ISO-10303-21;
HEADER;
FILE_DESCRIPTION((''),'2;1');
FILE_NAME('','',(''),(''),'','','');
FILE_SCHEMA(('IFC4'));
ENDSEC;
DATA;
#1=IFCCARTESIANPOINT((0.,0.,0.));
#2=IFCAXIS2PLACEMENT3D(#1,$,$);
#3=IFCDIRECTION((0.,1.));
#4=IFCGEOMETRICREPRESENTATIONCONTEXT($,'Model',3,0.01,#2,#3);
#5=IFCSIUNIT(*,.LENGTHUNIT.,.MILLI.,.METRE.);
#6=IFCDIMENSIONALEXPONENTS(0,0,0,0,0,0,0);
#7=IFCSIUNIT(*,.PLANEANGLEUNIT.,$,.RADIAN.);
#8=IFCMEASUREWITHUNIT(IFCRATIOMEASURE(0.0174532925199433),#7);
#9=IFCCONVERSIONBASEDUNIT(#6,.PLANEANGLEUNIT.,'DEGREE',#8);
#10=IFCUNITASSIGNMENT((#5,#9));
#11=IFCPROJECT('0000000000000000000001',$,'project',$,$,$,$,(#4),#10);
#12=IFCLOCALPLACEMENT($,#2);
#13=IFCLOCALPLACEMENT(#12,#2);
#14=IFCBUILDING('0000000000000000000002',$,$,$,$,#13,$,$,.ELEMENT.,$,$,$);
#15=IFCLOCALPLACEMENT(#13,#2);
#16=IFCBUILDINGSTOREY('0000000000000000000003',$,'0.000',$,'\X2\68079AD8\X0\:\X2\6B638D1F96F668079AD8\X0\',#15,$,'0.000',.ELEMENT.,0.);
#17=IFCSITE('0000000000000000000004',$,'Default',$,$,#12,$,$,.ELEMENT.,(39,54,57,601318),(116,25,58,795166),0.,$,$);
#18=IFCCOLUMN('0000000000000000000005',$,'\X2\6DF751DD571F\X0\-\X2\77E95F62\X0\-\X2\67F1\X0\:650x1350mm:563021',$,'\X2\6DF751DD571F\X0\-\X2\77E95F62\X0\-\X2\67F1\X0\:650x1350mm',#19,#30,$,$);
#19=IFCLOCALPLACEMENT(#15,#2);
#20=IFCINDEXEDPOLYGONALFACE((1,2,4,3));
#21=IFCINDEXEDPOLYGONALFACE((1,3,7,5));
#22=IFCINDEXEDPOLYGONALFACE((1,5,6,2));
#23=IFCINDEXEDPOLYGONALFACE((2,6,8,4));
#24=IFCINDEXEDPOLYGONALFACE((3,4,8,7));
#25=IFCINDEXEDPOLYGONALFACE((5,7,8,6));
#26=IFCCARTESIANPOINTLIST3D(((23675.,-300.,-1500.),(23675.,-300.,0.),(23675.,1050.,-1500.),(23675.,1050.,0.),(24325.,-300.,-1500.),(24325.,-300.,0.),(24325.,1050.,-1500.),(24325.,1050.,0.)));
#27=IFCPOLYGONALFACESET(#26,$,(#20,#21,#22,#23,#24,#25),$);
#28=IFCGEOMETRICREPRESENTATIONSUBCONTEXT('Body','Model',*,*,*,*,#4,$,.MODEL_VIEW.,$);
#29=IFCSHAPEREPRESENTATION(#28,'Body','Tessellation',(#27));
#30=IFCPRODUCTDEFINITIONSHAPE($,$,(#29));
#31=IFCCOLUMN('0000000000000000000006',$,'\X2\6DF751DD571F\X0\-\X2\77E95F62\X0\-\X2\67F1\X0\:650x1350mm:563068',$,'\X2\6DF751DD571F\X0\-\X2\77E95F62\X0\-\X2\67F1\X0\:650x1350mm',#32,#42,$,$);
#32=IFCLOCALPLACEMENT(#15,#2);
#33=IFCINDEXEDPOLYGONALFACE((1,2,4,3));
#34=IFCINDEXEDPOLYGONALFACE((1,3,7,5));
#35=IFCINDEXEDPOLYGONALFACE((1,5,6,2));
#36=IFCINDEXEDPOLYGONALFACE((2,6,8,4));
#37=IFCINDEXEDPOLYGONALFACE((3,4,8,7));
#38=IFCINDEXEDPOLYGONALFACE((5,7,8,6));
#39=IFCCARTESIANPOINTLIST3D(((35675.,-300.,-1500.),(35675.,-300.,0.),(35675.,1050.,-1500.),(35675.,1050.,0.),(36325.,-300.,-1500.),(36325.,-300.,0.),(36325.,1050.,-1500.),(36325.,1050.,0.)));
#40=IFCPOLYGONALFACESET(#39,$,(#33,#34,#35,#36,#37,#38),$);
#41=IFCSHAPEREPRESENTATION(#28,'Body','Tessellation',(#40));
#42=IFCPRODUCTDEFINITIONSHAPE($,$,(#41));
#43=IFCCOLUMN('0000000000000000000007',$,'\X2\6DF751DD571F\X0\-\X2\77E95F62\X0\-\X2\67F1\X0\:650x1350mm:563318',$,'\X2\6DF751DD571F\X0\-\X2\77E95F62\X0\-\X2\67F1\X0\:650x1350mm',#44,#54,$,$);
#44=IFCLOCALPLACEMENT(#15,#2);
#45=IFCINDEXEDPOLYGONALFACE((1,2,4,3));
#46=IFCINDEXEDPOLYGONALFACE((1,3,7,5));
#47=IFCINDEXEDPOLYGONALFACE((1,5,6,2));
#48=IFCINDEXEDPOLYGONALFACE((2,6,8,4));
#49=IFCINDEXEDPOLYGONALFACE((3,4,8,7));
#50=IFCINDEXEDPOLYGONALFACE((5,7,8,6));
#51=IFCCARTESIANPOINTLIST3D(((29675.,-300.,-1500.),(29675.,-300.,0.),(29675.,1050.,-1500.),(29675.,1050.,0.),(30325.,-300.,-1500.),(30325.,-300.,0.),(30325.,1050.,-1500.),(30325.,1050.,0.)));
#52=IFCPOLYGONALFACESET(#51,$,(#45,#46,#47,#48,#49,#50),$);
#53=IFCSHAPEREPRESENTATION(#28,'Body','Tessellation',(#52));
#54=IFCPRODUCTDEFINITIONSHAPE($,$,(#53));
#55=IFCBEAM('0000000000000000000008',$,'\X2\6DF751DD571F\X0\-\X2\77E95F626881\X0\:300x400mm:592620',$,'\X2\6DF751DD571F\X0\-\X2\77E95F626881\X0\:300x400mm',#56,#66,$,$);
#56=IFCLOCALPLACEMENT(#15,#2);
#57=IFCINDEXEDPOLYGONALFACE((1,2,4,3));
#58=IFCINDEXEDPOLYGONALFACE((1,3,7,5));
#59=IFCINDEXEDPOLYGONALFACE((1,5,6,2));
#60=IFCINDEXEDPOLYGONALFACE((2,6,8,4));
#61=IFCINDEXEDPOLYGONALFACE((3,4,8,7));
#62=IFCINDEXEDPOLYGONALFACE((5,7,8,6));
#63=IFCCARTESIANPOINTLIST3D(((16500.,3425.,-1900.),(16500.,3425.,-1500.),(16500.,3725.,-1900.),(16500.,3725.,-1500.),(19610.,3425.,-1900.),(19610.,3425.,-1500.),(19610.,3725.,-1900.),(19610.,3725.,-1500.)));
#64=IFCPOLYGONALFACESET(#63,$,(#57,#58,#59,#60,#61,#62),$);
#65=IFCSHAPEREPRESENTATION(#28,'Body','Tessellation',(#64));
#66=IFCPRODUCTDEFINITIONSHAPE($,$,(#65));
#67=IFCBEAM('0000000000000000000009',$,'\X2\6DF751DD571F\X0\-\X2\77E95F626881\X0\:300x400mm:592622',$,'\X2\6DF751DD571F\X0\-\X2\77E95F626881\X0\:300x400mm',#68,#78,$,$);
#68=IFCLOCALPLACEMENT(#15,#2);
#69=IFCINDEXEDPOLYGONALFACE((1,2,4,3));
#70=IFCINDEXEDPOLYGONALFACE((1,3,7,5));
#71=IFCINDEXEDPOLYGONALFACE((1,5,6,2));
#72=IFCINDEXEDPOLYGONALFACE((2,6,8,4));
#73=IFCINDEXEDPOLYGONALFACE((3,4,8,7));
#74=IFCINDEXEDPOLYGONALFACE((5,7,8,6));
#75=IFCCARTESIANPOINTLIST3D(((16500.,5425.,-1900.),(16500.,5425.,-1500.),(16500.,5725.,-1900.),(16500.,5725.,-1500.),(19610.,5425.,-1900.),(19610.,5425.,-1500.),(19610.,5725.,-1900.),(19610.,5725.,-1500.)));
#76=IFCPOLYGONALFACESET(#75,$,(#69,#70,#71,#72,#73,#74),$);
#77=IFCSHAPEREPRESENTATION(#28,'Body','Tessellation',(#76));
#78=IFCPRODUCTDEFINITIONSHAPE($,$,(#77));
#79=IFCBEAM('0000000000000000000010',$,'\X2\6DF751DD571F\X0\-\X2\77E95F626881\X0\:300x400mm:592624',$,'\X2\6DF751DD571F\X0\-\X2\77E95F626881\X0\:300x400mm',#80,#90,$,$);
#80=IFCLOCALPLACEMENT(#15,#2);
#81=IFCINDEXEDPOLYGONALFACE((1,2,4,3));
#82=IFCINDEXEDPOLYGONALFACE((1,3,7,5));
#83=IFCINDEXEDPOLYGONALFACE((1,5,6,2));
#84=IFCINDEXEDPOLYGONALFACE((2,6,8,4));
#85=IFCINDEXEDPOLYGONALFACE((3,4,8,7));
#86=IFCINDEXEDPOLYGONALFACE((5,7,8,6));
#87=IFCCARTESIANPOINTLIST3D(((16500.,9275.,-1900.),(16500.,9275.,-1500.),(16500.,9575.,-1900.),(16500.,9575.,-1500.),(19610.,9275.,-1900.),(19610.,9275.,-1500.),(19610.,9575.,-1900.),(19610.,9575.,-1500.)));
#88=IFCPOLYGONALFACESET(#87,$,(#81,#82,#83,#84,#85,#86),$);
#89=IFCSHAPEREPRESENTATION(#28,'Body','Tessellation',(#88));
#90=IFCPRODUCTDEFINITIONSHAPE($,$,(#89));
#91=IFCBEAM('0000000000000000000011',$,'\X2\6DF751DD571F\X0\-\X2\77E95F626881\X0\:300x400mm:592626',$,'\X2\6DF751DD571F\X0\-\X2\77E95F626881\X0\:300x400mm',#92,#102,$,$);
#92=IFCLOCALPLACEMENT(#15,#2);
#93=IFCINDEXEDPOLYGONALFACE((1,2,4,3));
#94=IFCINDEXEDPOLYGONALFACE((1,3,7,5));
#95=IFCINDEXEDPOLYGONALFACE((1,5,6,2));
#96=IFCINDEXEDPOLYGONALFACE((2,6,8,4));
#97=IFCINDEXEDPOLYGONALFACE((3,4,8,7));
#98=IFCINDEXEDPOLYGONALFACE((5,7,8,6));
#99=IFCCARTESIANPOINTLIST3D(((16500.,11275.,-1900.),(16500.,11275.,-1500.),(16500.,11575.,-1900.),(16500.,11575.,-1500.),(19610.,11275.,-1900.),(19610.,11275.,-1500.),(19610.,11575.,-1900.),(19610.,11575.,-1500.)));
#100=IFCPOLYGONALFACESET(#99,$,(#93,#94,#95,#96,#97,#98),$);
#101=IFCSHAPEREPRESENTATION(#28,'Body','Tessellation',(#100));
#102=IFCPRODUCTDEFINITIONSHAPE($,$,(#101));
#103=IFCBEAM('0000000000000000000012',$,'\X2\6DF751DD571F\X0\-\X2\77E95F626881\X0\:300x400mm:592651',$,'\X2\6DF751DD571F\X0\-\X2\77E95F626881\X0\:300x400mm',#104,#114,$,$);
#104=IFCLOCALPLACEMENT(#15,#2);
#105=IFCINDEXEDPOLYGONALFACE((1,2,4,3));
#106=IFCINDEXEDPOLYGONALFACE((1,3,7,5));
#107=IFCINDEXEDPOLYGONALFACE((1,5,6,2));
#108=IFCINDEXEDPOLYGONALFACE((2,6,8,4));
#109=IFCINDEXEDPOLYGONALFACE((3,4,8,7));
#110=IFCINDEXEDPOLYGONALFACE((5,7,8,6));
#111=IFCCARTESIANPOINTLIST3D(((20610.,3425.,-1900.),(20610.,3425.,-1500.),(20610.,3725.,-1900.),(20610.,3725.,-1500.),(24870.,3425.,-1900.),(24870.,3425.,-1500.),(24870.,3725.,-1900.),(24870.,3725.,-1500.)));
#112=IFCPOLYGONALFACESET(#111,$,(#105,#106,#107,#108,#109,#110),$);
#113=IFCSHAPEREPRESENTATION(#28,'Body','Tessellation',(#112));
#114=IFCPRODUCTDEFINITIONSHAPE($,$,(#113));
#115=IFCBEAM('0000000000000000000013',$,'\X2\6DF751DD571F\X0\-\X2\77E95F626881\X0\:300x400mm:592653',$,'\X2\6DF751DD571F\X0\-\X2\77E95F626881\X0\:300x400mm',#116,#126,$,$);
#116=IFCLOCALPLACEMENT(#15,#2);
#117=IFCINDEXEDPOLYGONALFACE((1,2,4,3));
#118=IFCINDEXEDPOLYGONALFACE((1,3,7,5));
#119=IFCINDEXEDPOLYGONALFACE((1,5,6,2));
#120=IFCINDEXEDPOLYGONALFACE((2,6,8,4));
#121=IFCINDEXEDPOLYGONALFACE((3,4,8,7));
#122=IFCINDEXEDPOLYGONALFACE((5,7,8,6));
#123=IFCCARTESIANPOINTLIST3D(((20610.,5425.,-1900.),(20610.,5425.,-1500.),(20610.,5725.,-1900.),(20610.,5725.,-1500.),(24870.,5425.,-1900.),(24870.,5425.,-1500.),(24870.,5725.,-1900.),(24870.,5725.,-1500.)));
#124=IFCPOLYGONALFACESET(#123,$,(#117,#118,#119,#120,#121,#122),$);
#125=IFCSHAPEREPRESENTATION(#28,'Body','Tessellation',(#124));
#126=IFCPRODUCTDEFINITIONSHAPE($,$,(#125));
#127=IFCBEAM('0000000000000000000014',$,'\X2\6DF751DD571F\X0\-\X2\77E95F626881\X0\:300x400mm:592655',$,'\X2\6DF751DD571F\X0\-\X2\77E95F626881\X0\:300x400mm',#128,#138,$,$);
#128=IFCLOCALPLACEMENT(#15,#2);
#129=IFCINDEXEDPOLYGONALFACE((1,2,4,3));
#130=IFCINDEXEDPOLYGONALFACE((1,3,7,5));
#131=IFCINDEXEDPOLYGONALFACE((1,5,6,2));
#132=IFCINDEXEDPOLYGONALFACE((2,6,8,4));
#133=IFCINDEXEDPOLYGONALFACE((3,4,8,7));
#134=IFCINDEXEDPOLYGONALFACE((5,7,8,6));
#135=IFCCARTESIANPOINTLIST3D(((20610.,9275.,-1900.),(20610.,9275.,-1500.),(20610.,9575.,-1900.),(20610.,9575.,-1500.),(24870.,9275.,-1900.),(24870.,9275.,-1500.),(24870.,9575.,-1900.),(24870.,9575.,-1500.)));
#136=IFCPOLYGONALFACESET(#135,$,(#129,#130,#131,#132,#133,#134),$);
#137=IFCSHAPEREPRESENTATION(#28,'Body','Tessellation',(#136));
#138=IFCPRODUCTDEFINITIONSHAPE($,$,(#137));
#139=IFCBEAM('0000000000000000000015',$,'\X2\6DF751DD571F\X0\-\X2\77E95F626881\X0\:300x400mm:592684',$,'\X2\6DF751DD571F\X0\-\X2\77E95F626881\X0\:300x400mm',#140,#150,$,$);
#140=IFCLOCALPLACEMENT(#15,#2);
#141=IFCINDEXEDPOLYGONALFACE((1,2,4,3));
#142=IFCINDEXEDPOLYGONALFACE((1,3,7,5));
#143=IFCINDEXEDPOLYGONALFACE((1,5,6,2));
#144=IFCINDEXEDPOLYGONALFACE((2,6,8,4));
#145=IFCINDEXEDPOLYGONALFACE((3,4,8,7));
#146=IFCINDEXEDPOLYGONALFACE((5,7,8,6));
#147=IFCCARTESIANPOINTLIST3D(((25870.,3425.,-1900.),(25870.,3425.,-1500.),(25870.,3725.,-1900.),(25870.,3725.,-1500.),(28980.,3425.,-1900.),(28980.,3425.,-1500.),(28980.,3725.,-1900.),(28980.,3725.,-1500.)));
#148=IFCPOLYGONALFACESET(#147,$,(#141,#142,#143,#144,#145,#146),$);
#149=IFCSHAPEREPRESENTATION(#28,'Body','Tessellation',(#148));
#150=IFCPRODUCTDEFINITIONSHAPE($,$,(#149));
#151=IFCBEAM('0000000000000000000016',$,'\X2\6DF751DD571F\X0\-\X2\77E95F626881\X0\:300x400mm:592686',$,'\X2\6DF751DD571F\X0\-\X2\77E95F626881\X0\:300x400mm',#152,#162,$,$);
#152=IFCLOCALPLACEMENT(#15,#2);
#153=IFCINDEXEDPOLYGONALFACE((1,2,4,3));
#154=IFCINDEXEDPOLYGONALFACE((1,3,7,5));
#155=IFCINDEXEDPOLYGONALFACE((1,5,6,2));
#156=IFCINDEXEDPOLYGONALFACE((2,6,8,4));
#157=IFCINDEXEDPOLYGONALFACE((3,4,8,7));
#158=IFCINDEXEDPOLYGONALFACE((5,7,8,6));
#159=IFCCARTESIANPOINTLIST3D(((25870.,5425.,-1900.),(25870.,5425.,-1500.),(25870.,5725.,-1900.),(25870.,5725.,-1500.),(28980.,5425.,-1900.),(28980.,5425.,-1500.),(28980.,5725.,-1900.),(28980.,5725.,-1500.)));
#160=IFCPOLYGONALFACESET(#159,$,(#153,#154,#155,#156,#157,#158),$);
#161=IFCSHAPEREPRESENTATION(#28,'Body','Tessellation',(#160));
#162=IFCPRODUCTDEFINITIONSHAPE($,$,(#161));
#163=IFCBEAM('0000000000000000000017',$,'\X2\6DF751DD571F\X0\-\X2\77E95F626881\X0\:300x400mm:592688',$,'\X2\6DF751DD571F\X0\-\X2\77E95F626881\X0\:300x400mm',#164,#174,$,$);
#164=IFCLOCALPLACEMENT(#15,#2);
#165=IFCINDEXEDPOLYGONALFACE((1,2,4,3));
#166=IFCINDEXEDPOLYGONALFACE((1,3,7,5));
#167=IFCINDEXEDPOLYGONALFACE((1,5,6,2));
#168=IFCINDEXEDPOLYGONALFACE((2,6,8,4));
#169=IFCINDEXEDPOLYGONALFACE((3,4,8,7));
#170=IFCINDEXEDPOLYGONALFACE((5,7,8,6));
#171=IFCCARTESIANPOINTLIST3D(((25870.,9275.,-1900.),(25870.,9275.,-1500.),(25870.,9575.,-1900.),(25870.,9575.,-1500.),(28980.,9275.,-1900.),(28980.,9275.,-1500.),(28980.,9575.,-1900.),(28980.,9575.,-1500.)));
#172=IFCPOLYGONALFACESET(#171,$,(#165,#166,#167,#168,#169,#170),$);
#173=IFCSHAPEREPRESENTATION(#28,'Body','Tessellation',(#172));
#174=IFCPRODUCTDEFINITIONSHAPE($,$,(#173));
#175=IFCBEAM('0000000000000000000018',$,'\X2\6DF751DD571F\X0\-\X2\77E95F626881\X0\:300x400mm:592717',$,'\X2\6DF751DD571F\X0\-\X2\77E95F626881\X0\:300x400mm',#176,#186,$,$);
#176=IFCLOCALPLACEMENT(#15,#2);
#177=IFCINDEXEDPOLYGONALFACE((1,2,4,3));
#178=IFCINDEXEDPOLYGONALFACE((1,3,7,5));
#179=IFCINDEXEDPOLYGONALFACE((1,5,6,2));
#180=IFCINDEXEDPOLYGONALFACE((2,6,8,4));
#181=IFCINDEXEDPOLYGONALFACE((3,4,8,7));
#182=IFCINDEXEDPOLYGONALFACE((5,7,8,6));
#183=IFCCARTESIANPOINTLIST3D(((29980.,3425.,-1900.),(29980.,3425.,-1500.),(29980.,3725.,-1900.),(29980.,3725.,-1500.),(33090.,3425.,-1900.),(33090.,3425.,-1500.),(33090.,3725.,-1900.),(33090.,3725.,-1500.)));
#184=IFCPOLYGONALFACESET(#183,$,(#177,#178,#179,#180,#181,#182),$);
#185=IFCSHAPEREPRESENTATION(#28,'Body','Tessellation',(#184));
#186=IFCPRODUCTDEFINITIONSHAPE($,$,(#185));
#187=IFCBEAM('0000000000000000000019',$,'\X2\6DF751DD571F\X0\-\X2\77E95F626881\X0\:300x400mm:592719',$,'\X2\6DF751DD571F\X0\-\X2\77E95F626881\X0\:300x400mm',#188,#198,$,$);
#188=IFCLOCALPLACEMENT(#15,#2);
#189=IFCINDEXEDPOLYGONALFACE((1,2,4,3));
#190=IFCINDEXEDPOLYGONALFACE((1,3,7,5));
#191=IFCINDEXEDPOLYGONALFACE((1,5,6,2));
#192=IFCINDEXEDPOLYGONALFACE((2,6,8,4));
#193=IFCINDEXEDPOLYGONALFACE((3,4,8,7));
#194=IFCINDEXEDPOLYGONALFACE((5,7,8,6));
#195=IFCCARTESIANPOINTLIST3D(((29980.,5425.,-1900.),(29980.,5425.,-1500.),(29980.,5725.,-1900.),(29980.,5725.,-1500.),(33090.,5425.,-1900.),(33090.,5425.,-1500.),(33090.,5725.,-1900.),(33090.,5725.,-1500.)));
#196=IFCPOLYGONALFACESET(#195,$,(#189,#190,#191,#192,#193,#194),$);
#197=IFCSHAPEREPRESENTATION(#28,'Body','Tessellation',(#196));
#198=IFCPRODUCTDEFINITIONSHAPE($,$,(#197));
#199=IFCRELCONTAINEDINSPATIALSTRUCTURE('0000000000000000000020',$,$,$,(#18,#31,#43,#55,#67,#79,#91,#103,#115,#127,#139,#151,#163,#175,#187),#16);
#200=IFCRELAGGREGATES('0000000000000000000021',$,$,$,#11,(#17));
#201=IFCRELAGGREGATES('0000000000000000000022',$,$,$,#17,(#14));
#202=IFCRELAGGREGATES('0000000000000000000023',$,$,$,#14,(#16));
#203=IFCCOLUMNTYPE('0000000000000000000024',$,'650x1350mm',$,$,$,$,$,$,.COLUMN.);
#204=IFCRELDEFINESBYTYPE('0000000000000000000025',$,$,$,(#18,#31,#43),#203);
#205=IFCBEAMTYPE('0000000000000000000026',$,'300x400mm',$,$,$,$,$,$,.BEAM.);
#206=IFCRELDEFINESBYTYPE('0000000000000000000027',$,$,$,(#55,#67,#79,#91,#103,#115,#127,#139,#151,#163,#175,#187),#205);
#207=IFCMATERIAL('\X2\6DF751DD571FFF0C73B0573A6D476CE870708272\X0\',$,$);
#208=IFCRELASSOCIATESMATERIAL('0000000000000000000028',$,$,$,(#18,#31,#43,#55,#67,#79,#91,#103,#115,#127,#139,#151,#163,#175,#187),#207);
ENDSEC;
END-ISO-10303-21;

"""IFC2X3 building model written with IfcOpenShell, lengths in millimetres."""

from ifc_helpers import new_model, entity, si_unit, converted_unit, direction, frame, frame_2d, origin, origin_2d_with_axis, place, context, subcontext, project, spatial, rectangle, extrude, source, transform, mapped, material, type_object, type_shapes, element, save


model = new_model("IFC2X3")

# Units and contexts
model_context = context("Model", 3, precision=0.01, world=origin(), true_north=direction((0.0, 1.0)))
body_context = subcontext(model_context, "Body", "Model", "MODEL_VIEW")
ifc_project = project(units=[si_unit("LENGTHUNIT", "METRE", prefix="MILLI"), converted_unit("PLANEANGLEUNIT", "DEGREE", entity("IfcRatioMeasure", 0.0174532925199433), si_unit("PLANEANGLEUNIT", "RADIAN"), dimensions=[0, 0, 0, 0, 0, 0, 0])], contexts=[model_context])

# Site, building, storey
site_placement = place(None, origin())
site = spatial("IfcSite", under=ifc_project, at=site_placement, Name="Default", CompositionType="ELEMENT", RefLatitude=(39, 54, 57, 601318), RefLongitude=(116, 25, 58, 795166), RefElevation=0.0)
building_placement = place(site_placement, origin())
building = spatial("IfcBuilding", under=site, at=building_placement, CompositionType="ELEMENT")
storey_placement = place(building_placement, origin())
storey = spatial("IfcBuildingStorey", under=building, at=storey_placement, Name="0.000", ObjectType="标高:正负零标高", LongName="0.000", CompositionType="ELEMENT", Elevation=0.0)

# Columns
ifc_material = material(Name="混凝土，现场浇注灰色")
column_type = type_object("IfcColumnType", Name="650x1350mm", PredefinedType="COLUMN")
shared_shape = source(origin(), body_context, "Body", "SweptSolid", [
    extrude(rectangle(XDim=1350.0, YDim=650.0, at=origin_2d_with_axis()), frame((0.0, 0.0, -1500.0), z_axis=(0.0, 0.0, 1.0), x_axis=(0.0, -1.0, 0.0)), (0.0, 0.0, 1.0), 1500.0),
])
type_shapes(column_type, [shared_shape])
for number, where, name in (
    (1, (24000.0, 375.0, 0.0), "混凝土-矩形-柱:650x1350mm:563021"),
    (2, (36000.0, 375.0, 0.0), "混凝土-矩形-柱:650x1350mm:563068"),
    (3, (30000.0, 375.0, 0.0), "混凝土-矩形-柱:650x1350mm:563318"),
):
    element("IfcColumn", number, at=place(storey_placement, frame(where)), inside=storey, type_object=column_type, material=ifc_material, Name=name, ObjectType="混凝土-矩形-柱:650x1350mm", context=body_context, shape_type="MappedRepresentation", body=[
        mapped(shared_shape, transform((0.0, 0.0, 0.0), scale=1.0)),
    ])

# Beams
beam_type_1 = type_object("IfcBeamType", Name="300x400mm", PredefinedType="BEAM")
beam_1_placement = place(storey_placement, frame((19610.0, 3575.0, -1500.0), z_axis=(0.0, 0.0, 1.0), x_axis=(-1.0, 0.0, 0.0)))
element("IfcBeam", 4, at=beam_1_placement, inside=storey, type_object=beam_type_1, material=ifc_material, Name="混凝土-矩形梁:300x400mm:592620", ObjectType="混凝土-矩形梁:300x400mm", context=body_context, shape_type="SweptSolid", body=[
    extrude(rectangle(XDim=400.0, YDim=300.0, at=frame_2d((0.0, 0.0), x_axis=(1.0, 0.0))), frame((0.0, 0.0, -200.0), z_axis=(1.0, 0.0, 0.0), x_axis=(0.0, 0.0, -1.0)), (0.0, 0.0, 1.0), 3110.0),
])
beam_2_placement = place(storey_placement, frame((19610.0, 5575.0, -1500.0), z_axis=(0.0, 0.0, 1.0), x_axis=(-1.0, 0.0, 0.0)))
element("IfcBeam", 5, at=beam_2_placement, inside=storey, type_object=beam_type_1, material=ifc_material, Name="混凝土-矩形梁:300x400mm:592622", ObjectType="混凝土-矩形梁:300x400mm", context=body_context, shape_type="SweptSolid", body=[
    extrude(rectangle(XDim=400.0, YDim=300.0, at=frame_2d((0.0, 0.0), x_axis=(1.0, 0.0))), frame((0.0, 0.0, -200.0), z_axis=(1.0, 0.0, 0.0), x_axis=(0.0, 0.0, -1.0)), (0.0, 0.0, 1.0), 3110.0),
])
beam_3_placement = place(storey_placement, frame((19610.0, 9425.0, -1500.0), z_axis=(0.0, 0.0, 1.0), x_axis=(-1.0, 0.0, 0.0)))
element("IfcBeam", 6, at=beam_3_placement, inside=storey, type_object=beam_type_1, material=ifc_material, Name="混凝土-矩形梁:300x400mm:592624", ObjectType="混凝土-矩形梁:300x400mm", context=body_context, shape_type="SweptSolid", body=[
    extrude(rectangle(XDim=400.0, YDim=300.0, at=frame_2d((0.0, 0.0), x_axis=(1.0, 0.0))), frame((0.0, 0.0, -200.0), z_axis=(1.0, 0.0, 0.0), x_axis=(0.0, 0.0, -1.0)), (0.0, 0.0, 1.0), 3110.0),
])
beam_4_placement = place(storey_placement, frame((19610.0, 11425.0, -1500.0), z_axis=(0.0, 0.0, 1.0), x_axis=(-1.0, 0.0, 0.0)))
element("IfcBeam", 7, at=beam_4_placement, inside=storey, type_object=beam_type_1, material=ifc_material, Name="混凝土-矩形梁:300x400mm:592626", ObjectType="混凝土-矩形梁:300x400mm", context=body_context, shape_type="SweptSolid", body=[
    extrude(rectangle(XDim=400.0, YDim=300.0, at=frame_2d((0.0, 0.0), x_axis=(1.0, 0.0))), frame((0.0, 0.0, -200.0), z_axis=(1.0, 0.0, 0.0), x_axis=(0.0, 0.0, -1.0)), (0.0, 0.0, 1.0), 3110.0),
])
beam_5_placement = place(storey_placement, frame((24870.0, 3575.0, -1500.0), z_axis=(0.0, 0.0, 1.0), x_axis=(-1.0, 0.0, 0.0)))
element("IfcBeam", 8, at=beam_5_placement, inside=storey, type_object=beam_type_1, material=ifc_material, Name="混凝土-矩形梁:300x400mm:592651", ObjectType="混凝土-矩形梁:300x400mm", context=body_context, shape_type="SweptSolid", body=[
    extrude(rectangle(XDim=400.0, YDim=300.0, at=frame_2d((0.0, 0.0), x_axis=(1.0, 0.0))), frame((0.0, 0.0, -200.0), z_axis=(1.0, 0.0, 0.0), x_axis=(0.0, 0.0, -1.0)), (0.0, 0.0, 1.0), 4260.0),
])
beam_6_placement = place(storey_placement, frame((24870.0, 5575.0, -1500.0), z_axis=(0.0, 0.0, 1.0), x_axis=(-1.0, 0.0, 0.0)))
element("IfcBeam", 9, at=beam_6_placement, inside=storey, type_object=beam_type_1, material=ifc_material, Name="混凝土-矩形梁:300x400mm:592653", ObjectType="混凝土-矩形梁:300x400mm", context=body_context, shape_type="SweptSolid", body=[
    extrude(rectangle(XDim=400.0, YDim=300.0, at=frame_2d((0.0, 0.0), x_axis=(1.0, 0.0))), frame((0.0, 0.0, -200.0), z_axis=(1.0, 0.0, 0.0), x_axis=(0.0, 0.0, -1.0)), (0.0, 0.0, 1.0), 4260.0),
])
beam_7_placement = place(storey_placement, frame((24870.0, 9425.0, -1500.0), z_axis=(0.0, 0.0, 1.0), x_axis=(-1.0, 0.0, 0.0)))
element("IfcBeam", 10, at=beam_7_placement, inside=storey, type_object=beam_type_1, material=ifc_material, Name="混凝土-矩形梁:300x400mm:592655", ObjectType="混凝土-矩形梁:300x400mm", context=body_context, shape_type="SweptSolid", body=[
    extrude(rectangle(XDim=400.0, YDim=300.0, at=frame_2d((0.0, 0.0), x_axis=(1.0, 0.0))), frame((0.0, 0.0, -200.0), z_axis=(1.0, 0.0, 0.0), x_axis=(0.0, 0.0, -1.0)), (0.0, 0.0, 1.0), 4260.0),
])
beam_8_placement = place(storey_placement, frame((28980.0, 3575.0, -1500.0), z_axis=(0.0, 0.0, 1.0), x_axis=(-1.0, 0.0, 0.0)))
element("IfcBeam", 11, at=beam_8_placement, inside=storey, type_object=beam_type_1, material=ifc_material, Name="混凝土-矩形梁:300x400mm:592684", ObjectType="混凝土-矩形梁:300x400mm", context=body_context, shape_type="SweptSolid", body=[
    extrude(rectangle(XDim=400.0, YDim=300.0, at=frame_2d((0.0, 0.0), x_axis=(1.0, 0.0))), frame((0.0, 0.0, -200.0), z_axis=(1.0, 0.0, 0.0), x_axis=(0.0, 0.0, -1.0)), (0.0, 0.0, 1.0), 3110.0),
])
beam_9_placement = place(storey_placement, frame((28980.0, 5575.0, -1500.0), z_axis=(0.0, 0.0, 1.0), x_axis=(-1.0, 0.0, 0.0)))
element("IfcBeam", 12, at=beam_9_placement, inside=storey, type_object=beam_type_1, material=ifc_material, Name="混凝土-矩形梁:300x400mm:592686", ObjectType="混凝土-矩形梁:300x400mm", context=body_context, shape_type="SweptSolid", body=[
    extrude(rectangle(XDim=400.0, YDim=300.0, at=frame_2d((0.0, 0.0), x_axis=(1.0, 0.0))), frame((0.0, 0.0, -200.0), z_axis=(1.0, 0.0, 0.0), x_axis=(0.0, 0.0, -1.0)), (0.0, 0.0, 1.0), 3110.0),
])
beam_10_placement = place(storey_placement, frame((28980.0, 9425.0, -1500.0), z_axis=(0.0, 0.0, 1.0), x_axis=(-1.0, 0.0, 0.0)))
element("IfcBeam", 13, at=beam_10_placement, inside=storey, type_object=beam_type_1, material=ifc_material, Name="混凝土-矩形梁:300x400mm:592688", ObjectType="混凝土-矩形梁:300x400mm", context=body_context, shape_type="SweptSolid", body=[
    extrude(rectangle(XDim=400.0, YDim=300.0, at=frame_2d((0.0, 0.0), x_axis=(1.0, 0.0))), frame((0.0, 0.0, -200.0), z_axis=(1.0, 0.0, 0.0), x_axis=(0.0, 0.0, -1.0)), (0.0, 0.0, 1.0), 3110.0),
])
beam_11_placement = place(storey_placement, frame((33090.0, 3575.0, -1500.0), z_axis=(0.0, 0.0, 1.0), x_axis=(-1.0, 0.0, 0.0)))
element("IfcBeam", 14, at=beam_11_placement, inside=storey, type_object=beam_type_1, material=ifc_material, Name="混凝土-矩形梁:300x400mm:592717", ObjectType="混凝土-矩形梁:300x400mm", context=body_context, shape_type="SweptSolid", body=[
    extrude(rectangle(XDim=400.0, YDim=300.0, at=frame_2d((0.0, 0.0), x_axis=(1.0, 0.0))), frame((0.0, 0.0, -200.0), z_axis=(1.0, 0.0, 0.0), x_axis=(0.0, 0.0, -1.0)), (0.0, 0.0, 1.0), 3110.0),
])
beam_12_placement = place(storey_placement, frame((33090.0, 5575.0, -1500.0), z_axis=(0.0, 0.0, 1.0), x_axis=(-1.0, 0.0, 0.0)))
element("IfcBeam", 15, at=beam_12_placement, inside=storey, type_object=beam_type_1, material=ifc_material, Name="混凝土-矩形梁:300x400mm:592719", ObjectType="混凝土-矩形梁:300x400mm", context=body_context, shape_type="SweptSolid", body=[
    extrude(rectangle(XDim=400.0, YDim=300.0, at=frame_2d((0.0, 0.0), x_axis=(1.0, 0.0))), frame((0.0, 0.0, -200.0), z_axis=(1.0, 0.0, 0.0), x_axis=(0.0, 0.0, -1.0)), (0.0, 0.0, 1.0), 3110.0),
])

save(model, "model.ifc")
